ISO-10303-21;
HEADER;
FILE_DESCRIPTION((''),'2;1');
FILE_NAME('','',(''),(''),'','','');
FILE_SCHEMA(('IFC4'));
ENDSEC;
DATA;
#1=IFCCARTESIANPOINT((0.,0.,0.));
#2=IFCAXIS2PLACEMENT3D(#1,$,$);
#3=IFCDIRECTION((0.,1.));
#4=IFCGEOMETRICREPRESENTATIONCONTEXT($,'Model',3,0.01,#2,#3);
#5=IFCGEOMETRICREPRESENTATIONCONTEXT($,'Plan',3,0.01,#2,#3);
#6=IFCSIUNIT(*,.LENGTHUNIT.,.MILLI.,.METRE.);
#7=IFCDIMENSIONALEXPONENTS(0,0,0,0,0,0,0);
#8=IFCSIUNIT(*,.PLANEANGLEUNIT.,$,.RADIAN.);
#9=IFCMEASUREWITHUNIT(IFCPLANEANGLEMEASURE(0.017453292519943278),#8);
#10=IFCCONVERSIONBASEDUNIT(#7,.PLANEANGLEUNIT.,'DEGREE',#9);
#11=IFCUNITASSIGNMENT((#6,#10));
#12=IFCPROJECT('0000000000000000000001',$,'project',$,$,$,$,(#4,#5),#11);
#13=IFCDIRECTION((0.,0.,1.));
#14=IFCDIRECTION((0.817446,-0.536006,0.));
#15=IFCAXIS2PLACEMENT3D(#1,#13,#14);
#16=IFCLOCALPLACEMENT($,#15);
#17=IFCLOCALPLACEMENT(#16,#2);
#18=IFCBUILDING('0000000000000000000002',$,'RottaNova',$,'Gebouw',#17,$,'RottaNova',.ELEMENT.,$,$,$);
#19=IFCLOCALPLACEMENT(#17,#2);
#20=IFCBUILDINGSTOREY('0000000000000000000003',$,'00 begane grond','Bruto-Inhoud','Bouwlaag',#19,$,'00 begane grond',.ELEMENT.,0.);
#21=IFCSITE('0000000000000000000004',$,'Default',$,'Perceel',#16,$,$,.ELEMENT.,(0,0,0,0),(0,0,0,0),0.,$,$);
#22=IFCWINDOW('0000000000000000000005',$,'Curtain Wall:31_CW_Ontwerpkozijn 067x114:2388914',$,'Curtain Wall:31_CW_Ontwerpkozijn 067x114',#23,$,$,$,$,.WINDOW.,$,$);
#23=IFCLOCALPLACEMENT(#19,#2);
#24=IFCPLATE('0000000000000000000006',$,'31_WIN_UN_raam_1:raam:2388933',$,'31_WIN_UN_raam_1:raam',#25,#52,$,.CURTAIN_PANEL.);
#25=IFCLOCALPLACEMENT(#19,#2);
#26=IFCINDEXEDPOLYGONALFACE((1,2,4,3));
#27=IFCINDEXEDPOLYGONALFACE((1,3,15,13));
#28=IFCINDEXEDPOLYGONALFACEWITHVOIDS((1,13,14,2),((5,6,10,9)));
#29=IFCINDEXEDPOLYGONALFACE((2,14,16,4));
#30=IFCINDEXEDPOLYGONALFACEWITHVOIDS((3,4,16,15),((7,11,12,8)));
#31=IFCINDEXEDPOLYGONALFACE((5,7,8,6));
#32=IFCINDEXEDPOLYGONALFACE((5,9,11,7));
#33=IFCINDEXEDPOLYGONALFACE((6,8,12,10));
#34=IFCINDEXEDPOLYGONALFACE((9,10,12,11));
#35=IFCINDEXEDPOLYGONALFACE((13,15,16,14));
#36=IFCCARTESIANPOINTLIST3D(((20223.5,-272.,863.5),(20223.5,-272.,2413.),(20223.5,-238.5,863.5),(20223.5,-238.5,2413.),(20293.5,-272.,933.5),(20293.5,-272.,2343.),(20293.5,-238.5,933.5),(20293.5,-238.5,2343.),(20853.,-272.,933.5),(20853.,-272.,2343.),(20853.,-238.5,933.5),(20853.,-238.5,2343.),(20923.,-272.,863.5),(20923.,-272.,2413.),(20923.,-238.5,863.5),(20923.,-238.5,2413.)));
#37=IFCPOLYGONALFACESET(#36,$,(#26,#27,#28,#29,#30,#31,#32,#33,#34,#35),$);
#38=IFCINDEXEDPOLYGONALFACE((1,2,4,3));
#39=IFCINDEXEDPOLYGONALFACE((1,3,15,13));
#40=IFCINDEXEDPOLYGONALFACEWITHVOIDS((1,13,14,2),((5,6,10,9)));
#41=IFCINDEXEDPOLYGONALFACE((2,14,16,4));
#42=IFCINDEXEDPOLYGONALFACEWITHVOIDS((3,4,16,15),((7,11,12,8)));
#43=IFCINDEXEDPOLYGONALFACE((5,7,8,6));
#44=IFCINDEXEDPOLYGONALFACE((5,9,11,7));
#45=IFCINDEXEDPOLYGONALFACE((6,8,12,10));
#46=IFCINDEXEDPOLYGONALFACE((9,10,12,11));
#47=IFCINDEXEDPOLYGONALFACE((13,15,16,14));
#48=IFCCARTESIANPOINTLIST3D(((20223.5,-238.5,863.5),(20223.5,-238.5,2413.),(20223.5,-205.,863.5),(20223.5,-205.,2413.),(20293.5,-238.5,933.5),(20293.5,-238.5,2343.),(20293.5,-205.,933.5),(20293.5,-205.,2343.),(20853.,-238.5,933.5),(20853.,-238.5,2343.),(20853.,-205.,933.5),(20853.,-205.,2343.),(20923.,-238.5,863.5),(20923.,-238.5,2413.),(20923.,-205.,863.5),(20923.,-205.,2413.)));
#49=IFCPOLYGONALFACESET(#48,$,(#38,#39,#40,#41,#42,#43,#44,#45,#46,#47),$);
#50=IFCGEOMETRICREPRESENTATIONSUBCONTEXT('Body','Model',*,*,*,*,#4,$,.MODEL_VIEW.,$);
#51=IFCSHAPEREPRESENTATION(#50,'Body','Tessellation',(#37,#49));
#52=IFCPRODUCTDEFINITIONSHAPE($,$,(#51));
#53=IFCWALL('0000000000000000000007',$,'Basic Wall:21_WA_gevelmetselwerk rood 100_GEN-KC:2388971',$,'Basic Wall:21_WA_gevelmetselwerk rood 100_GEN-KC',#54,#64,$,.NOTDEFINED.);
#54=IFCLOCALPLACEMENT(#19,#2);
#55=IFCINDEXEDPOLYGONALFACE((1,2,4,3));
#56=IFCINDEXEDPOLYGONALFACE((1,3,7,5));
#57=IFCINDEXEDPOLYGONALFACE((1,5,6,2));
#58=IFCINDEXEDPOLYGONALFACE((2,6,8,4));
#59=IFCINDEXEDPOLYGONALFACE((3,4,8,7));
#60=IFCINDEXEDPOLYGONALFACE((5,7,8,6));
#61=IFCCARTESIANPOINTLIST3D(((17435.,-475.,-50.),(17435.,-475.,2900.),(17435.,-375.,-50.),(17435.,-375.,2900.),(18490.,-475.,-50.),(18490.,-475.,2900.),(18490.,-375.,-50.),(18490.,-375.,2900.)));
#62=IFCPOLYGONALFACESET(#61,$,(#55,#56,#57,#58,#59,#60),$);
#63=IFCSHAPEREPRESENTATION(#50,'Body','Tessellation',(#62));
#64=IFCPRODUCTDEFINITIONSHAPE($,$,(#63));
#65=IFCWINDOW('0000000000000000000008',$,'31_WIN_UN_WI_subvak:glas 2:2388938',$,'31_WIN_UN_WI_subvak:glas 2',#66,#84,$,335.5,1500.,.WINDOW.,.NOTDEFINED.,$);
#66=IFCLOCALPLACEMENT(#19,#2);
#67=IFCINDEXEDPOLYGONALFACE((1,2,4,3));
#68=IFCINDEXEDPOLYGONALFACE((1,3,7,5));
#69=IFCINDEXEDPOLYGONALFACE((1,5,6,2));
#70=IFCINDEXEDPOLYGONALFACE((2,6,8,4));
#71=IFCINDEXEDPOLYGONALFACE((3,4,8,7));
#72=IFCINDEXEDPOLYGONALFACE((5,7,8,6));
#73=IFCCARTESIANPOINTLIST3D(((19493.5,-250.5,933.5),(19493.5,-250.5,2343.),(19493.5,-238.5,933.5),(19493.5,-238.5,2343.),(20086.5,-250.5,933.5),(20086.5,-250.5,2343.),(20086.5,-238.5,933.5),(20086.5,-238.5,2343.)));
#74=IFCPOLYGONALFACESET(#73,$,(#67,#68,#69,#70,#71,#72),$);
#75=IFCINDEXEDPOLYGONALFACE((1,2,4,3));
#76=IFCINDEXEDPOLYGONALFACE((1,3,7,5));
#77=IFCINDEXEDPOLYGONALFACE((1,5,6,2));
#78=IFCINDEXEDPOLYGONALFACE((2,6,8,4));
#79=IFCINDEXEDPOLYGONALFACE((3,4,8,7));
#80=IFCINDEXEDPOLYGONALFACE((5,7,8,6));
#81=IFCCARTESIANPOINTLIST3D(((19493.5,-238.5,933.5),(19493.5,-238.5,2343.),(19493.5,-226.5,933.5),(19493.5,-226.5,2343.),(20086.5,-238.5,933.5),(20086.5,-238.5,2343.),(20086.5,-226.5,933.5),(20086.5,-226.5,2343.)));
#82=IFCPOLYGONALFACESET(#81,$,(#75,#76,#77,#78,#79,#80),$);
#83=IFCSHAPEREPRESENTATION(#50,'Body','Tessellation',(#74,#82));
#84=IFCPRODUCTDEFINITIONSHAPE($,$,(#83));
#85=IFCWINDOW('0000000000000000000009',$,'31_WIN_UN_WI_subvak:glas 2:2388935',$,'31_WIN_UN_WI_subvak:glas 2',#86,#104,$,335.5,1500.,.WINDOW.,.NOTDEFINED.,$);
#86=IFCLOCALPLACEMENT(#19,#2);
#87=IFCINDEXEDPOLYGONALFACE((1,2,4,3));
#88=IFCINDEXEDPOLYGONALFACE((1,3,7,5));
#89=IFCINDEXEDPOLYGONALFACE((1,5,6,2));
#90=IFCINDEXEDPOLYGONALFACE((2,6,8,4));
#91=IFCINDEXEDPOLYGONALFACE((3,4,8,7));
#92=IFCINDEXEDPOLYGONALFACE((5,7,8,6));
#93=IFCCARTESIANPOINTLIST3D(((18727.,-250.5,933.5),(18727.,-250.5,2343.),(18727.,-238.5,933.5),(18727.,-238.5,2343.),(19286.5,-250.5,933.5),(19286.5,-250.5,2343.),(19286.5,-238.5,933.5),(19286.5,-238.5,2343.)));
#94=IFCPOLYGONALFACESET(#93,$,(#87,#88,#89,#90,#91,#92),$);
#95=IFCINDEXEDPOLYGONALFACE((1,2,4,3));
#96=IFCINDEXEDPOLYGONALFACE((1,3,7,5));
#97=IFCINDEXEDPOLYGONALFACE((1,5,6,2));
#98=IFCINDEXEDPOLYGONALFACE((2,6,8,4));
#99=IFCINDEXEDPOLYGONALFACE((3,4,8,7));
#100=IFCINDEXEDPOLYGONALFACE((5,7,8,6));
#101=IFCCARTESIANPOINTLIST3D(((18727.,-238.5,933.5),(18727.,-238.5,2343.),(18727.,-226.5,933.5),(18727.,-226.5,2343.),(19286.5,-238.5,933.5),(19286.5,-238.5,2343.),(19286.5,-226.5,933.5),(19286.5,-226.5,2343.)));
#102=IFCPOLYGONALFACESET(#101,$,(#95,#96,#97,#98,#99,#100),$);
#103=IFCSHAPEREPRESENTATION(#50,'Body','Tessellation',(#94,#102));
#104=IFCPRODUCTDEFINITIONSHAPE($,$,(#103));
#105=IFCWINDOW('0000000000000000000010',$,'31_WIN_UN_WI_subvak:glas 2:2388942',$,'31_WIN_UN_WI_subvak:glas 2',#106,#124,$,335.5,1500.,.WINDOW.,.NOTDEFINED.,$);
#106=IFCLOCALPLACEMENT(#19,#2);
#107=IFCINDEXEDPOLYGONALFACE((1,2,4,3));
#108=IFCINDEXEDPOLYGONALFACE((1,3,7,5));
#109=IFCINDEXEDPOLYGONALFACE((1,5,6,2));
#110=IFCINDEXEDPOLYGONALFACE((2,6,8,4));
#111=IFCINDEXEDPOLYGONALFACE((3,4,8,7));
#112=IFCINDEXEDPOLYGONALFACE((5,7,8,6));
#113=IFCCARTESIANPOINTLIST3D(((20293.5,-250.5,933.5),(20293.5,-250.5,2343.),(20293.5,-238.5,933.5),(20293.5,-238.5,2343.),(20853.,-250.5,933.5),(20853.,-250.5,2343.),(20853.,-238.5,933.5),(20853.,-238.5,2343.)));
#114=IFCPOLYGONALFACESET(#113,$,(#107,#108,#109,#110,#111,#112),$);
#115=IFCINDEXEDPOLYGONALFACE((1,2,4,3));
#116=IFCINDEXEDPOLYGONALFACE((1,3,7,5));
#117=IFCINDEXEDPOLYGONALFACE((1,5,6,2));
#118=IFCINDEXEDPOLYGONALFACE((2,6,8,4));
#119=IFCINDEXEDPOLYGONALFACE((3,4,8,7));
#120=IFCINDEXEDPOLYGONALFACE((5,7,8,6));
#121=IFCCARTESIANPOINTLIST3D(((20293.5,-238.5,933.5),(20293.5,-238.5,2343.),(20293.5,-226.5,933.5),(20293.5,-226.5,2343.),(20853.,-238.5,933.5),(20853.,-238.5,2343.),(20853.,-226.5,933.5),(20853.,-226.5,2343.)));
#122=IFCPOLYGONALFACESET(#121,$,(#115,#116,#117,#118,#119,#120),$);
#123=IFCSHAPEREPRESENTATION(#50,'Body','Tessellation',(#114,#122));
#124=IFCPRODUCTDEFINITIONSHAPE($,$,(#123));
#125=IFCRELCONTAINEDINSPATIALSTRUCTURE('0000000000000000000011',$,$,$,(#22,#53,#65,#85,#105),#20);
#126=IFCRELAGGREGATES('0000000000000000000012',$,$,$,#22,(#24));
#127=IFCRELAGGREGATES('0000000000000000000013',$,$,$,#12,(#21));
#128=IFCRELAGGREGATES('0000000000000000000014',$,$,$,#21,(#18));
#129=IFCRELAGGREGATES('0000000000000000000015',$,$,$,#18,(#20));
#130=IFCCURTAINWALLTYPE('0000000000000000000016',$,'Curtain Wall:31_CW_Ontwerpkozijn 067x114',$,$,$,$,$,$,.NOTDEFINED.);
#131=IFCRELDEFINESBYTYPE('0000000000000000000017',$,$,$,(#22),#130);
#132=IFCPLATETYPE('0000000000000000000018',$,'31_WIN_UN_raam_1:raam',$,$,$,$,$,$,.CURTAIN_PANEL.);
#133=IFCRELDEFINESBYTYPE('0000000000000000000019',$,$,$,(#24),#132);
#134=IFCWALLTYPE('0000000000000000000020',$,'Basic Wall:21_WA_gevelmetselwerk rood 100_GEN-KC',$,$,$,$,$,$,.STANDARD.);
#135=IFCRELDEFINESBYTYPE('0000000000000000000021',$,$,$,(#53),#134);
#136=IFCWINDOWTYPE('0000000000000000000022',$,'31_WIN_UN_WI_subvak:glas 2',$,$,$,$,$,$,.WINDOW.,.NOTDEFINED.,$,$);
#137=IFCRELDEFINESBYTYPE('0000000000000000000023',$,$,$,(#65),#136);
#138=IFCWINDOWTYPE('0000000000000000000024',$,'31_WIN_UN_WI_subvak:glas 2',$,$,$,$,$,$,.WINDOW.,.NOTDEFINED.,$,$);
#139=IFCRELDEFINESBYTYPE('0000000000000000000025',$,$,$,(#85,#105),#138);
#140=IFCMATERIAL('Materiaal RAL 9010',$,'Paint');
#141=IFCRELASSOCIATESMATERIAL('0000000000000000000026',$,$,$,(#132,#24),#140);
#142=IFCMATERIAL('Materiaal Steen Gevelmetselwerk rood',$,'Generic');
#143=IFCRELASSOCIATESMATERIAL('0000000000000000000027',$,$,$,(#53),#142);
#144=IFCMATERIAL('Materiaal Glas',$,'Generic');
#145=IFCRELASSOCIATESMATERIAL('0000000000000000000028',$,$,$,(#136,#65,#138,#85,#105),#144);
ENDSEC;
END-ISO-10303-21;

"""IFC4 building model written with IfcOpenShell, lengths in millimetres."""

from ifc_helpers import new_model, entity, si_unit, converted_unit, direction, frame, origin, place, context, subcontext, project, spatial, indexed_curve, outline, extrude, source, transform, mapped, material, type_object, type_shapes, element, aggregate, save


model = new_model("IFC4")

# Units and contexts
model_context = context("Model", 3, precision=0.01, world=origin(), true_north=direction((0.0, 1.0)))
plan_context = context("Plan", 3, precision=0.01, world=origin(), true_north=direction((0.0, 1.0)))
body_context = subcontext(model_context, "Body", "Model", "MODEL_VIEW")
ifc_project = project(units=[si_unit("LENGTHUNIT", "METRE", prefix="MILLI"), converted_unit("PLANEANGLEUNIT", "DEGREE", entity("IfcPlaneAngleMeasure", 0.017453292519943278), si_unit("PLANEANGLEUNIT", "RADIAN"), dimensions=[0, 0, 0, 0, 0, 0, 0])], contexts=[model_context, plan_context])

# Site, building, storey
site_placement = place(None, frame((0.0, 0.0, 0.0), z_axis=(0.0, 0.0, 1.0), x_axis=(0.817446, -0.536006, 0.0)))
site = spatial("IfcSite", under=ifc_project, at=site_placement, Name="Default", ObjectType="Perceel", CompositionType="ELEMENT", RefLatitude=(0, 0, 0, 0), RefLongitude=(0, 0, 0, 0), RefElevation=0.0)
building_placement = place(site_placement, origin())
building = spatial("IfcBuilding", under=site, at=building_placement, Name="RottaNova", ObjectType="Gebouw", LongName="RottaNova", CompositionType="ELEMENT")
storey_placement = place(building_placement, origin())
storey = spatial("IfcBuildingStorey", under=building, at=storey_placement, Name="00 begane grond", Description="Bruto-Inhoud", ObjectType="Bouwlaag", LongName="00 begane grond", CompositionType="ELEMENT", Elevation=0.0)

# Window, plate
curtain_wall_type = type_object("IfcCurtainWallType", Name="Curtain Wall:31_CW_Ontwerpkozijn 067x114", PredefinedType="NOTDEFINED")
window_1_placement = place(storey_placement, origin())
window_1 = element("IfcWindow", 1, at=window_1_placement, inside=storey, type_object=curtain_wall_type, Name="Curtain Wall:31_CW_Ontwerpkozijn 067x114:2388914", ObjectType="Curtain Wall:31_CW_Ontwerpkozijn 067x114", PredefinedType="WINDOW")
ifc_material_1 = material(Name="Materiaal Glas", Category="Generic")
ifc_material_2 = material(Name="Materiaal RAL 9010", Category="Paint")
plate_type_1 = type_object("IfcPlateType", Name="31_WIN_UN_raam_1:raam", PredefinedType="CURTAIN_PANEL", material=ifc_material_2)
shared_shape_1 = source(origin(), body_context, "Body", "SweptSolid", [
    extrude(outline(indexed_curve([(-349.7, -774.8), (349.7, -774.8), (349.7, 774.8), (-349.7, 774.8), (-349.7, -774.8)], self_intersect=False), holes=[indexed_curve([(-279.7, 704.8), (279.7, 704.8), (279.7, -704.8), (-279.7, -704.8), (-279.7, 704.8)], self_intersect=False)]), frame((0.0, -92.0, 774.8), z_axis=(0.0, 1.0, 0.0), x_axis=(1.0, 0.0, 0.0)), (0.0, 0.0, 1.0), 33.5),
    extrude(outline(indexed_curve([(-349.7, -774.8), (349.7, -774.8), (349.7, 774.8), (-349.7, 774.8), (-349.7, -774.8)], self_intersect=False), holes=[indexed_curve([(-279.7, 704.7), (279.7, 704.7), (279.7, -704.8), (-279.7, -704.8), (-279.7, 704.7)], self_intersect=False)]), frame((0.0, -58.5, 774.8), z_axis=(0.0, 1.0, 0.0), x_axis=(1.0, 0.0, 0.0)), (0.0, 0.0, 1.0), 33.5),
])
type_shapes(plate_type_1, [shared_shape_1])
plate_1_placement = place(window_1_placement, frame((20573.3, -180.0, 863.5)))
plate_1 = element("IfcPlate", 2, at=plate_1_placement, type_object=plate_type_1, material=ifc_material_2, Name="31_WIN_UN_raam_1:raam:2388933", ObjectType="31_WIN_UN_raam_1:raam", PredefinedType="CURTAIN_PANEL", context=body_context, shape_type="MappedRepresentation", body=[
    mapped(shared_shape_1, transform((0.0, 0.0, 0.0), scale=1.0)),
])
aggregate(window_1, [plate_1])

# Wall
ifc_material_3 = material(Name="Materiaal Steen Gevelmetselwerk rood", Category="Generic")
wall_type = type_object("IfcWallType", Name="Basic Wall:21_WA_gevelmetselwerk rood 100_GEN-KC", PredefinedType="STANDARD")
wall_placement = place(storey_placement, frame((18490.0, -425.0, -50.0), z_axis=(0.0, 0.0, 1.0), x_axis=(-1.0, 0.0, 0.0)))
element("IfcWall", 3, at=wall_placement, inside=storey, type_object=wall_type, material=ifc_material_3, Name="Basic Wall:21_WA_gevelmetselwerk rood 100_GEN-KC:2388971", ObjectType="Basic Wall:21_WA_gevelmetselwerk rood 100_GEN-KC", PredefinedType="NOTDEFINED", context=body_context, shape_type="SweptSolid", body=[
    extrude(outline(indexed_curve([(1055.0, 50.0), (0.0, 50.0), (0.0, -50.0), (1055.0, -50.0), (1055.0, 50.0)], self_intersect=False)), origin(), (0.0, 0.0, 1.0), 2950.0),
])

# Windows
window_type_1 = type_object("IfcWindowType", Name="31_WIN_UN_WI_subvak:glas 2", PartitioningType="NOTDEFINED", PredefinedType="WINDOW", material=ifc_material_1)
shared_shape_2 = source(origin(), body_context, "Body", "SweptSolid", [
    extrude(outline(indexed_curve([(-296.5, -6.0), (296.5, -6.0), (296.5, 6.0), (-296.5, 6.0), (-296.5, -6.0)], self_intersect=False)), frame((0.0, -6.0, 0.0)), (0.0, 0.0, 1.0), 1409.5),
    extrude(outline(indexed_curve([(-296.5, -6.0), (296.5, -6.0), (296.5, 6.0), (-296.5, 6.0), (-296.5, -6.0)], self_intersect=False)), frame((0.0, 6.0, 0.0)), (0.0, 0.0, 1.0), 1409.5),
])
type_shapes(window_type_1, [shared_shape_2])
window_2_placement = place(storey_placement, frame((19790.0, -238.5, 933.5)))
element("IfcWindow", 4, at=window_2_placement, inside=storey, type_object=window_type_1, material=ifc_material_1, Name="31_WIN_UN_WI_subvak:glas 2:2388938", ObjectType="31_WIN_UN_WI_subvak:glas 2", OverallHeight=335.5, OverallWidth=1500.0, PartitioningType="NOTDEFINED", PredefinedType="WINDOW", context=body_context, shape_type="MappedRepresentation", body=[
    mapped(shared_shape_2, transform((0.0, 0.0, 0.0), scale=1.0)),
])
window_type_2 = type_object("IfcWindowType", Name="31_WIN_UN_WI_subvak:glas 2", PartitioningType="NOTDEFINED", PredefinedType="WINDOW", material=ifc_material_1)
shared_shape_3 = source(origin(), body_context, "Body", "SweptSolid", [
    extrude(outline(indexed_curve([(-279.8, -6.0), (279.8, -6.0), (279.8, 6.0), (-279.8, 6.0), (-279.8, -6.0)], self_intersect=False)), frame((0.0, -6.0, 0.0)), (0.0, 0.0, 1.0), 1409.5),
    extrude(outline(indexed_curve([(-279.8, -6.0), (279.8, -6.0), (279.8, 6.0), (-279.8, 6.0), (-279.8, -6.0)], self_intersect=False)), frame((0.0, 6.0, 0.0)), (0.0, 0.0, 1.0), 1409.5),
])
type_shapes(window_type_2, [shared_shape_3])
for number, where, name in (
    (5, (19006.8, -238.5, 933.5), "31_WIN_UN_WI_subvak:glas 2:2388935"),
    (6, (20573.3, -238.5, 933.5), "31_WIN_UN_WI_subvak:glas 2:2388942"),
):
    element("IfcWindow", number, at=place(storey_placement, frame(where)), inside=storey, type_object=window_type_2, material=ifc_material_1, Name=name, ObjectType="31_WIN_UN_WI_subvak:glas 2", OverallHeight=335.5, OverallWidth=1500.0, PartitioningType="NOTDEFINED", PredefinedType="WINDOW", context=body_context, shape_type="MappedRepresentation", body=[
        mapped(shared_shape_3, transform((0.0, 0.0, 0.0), scale=1.0)),
    ])

save(model, "model.ifc")
